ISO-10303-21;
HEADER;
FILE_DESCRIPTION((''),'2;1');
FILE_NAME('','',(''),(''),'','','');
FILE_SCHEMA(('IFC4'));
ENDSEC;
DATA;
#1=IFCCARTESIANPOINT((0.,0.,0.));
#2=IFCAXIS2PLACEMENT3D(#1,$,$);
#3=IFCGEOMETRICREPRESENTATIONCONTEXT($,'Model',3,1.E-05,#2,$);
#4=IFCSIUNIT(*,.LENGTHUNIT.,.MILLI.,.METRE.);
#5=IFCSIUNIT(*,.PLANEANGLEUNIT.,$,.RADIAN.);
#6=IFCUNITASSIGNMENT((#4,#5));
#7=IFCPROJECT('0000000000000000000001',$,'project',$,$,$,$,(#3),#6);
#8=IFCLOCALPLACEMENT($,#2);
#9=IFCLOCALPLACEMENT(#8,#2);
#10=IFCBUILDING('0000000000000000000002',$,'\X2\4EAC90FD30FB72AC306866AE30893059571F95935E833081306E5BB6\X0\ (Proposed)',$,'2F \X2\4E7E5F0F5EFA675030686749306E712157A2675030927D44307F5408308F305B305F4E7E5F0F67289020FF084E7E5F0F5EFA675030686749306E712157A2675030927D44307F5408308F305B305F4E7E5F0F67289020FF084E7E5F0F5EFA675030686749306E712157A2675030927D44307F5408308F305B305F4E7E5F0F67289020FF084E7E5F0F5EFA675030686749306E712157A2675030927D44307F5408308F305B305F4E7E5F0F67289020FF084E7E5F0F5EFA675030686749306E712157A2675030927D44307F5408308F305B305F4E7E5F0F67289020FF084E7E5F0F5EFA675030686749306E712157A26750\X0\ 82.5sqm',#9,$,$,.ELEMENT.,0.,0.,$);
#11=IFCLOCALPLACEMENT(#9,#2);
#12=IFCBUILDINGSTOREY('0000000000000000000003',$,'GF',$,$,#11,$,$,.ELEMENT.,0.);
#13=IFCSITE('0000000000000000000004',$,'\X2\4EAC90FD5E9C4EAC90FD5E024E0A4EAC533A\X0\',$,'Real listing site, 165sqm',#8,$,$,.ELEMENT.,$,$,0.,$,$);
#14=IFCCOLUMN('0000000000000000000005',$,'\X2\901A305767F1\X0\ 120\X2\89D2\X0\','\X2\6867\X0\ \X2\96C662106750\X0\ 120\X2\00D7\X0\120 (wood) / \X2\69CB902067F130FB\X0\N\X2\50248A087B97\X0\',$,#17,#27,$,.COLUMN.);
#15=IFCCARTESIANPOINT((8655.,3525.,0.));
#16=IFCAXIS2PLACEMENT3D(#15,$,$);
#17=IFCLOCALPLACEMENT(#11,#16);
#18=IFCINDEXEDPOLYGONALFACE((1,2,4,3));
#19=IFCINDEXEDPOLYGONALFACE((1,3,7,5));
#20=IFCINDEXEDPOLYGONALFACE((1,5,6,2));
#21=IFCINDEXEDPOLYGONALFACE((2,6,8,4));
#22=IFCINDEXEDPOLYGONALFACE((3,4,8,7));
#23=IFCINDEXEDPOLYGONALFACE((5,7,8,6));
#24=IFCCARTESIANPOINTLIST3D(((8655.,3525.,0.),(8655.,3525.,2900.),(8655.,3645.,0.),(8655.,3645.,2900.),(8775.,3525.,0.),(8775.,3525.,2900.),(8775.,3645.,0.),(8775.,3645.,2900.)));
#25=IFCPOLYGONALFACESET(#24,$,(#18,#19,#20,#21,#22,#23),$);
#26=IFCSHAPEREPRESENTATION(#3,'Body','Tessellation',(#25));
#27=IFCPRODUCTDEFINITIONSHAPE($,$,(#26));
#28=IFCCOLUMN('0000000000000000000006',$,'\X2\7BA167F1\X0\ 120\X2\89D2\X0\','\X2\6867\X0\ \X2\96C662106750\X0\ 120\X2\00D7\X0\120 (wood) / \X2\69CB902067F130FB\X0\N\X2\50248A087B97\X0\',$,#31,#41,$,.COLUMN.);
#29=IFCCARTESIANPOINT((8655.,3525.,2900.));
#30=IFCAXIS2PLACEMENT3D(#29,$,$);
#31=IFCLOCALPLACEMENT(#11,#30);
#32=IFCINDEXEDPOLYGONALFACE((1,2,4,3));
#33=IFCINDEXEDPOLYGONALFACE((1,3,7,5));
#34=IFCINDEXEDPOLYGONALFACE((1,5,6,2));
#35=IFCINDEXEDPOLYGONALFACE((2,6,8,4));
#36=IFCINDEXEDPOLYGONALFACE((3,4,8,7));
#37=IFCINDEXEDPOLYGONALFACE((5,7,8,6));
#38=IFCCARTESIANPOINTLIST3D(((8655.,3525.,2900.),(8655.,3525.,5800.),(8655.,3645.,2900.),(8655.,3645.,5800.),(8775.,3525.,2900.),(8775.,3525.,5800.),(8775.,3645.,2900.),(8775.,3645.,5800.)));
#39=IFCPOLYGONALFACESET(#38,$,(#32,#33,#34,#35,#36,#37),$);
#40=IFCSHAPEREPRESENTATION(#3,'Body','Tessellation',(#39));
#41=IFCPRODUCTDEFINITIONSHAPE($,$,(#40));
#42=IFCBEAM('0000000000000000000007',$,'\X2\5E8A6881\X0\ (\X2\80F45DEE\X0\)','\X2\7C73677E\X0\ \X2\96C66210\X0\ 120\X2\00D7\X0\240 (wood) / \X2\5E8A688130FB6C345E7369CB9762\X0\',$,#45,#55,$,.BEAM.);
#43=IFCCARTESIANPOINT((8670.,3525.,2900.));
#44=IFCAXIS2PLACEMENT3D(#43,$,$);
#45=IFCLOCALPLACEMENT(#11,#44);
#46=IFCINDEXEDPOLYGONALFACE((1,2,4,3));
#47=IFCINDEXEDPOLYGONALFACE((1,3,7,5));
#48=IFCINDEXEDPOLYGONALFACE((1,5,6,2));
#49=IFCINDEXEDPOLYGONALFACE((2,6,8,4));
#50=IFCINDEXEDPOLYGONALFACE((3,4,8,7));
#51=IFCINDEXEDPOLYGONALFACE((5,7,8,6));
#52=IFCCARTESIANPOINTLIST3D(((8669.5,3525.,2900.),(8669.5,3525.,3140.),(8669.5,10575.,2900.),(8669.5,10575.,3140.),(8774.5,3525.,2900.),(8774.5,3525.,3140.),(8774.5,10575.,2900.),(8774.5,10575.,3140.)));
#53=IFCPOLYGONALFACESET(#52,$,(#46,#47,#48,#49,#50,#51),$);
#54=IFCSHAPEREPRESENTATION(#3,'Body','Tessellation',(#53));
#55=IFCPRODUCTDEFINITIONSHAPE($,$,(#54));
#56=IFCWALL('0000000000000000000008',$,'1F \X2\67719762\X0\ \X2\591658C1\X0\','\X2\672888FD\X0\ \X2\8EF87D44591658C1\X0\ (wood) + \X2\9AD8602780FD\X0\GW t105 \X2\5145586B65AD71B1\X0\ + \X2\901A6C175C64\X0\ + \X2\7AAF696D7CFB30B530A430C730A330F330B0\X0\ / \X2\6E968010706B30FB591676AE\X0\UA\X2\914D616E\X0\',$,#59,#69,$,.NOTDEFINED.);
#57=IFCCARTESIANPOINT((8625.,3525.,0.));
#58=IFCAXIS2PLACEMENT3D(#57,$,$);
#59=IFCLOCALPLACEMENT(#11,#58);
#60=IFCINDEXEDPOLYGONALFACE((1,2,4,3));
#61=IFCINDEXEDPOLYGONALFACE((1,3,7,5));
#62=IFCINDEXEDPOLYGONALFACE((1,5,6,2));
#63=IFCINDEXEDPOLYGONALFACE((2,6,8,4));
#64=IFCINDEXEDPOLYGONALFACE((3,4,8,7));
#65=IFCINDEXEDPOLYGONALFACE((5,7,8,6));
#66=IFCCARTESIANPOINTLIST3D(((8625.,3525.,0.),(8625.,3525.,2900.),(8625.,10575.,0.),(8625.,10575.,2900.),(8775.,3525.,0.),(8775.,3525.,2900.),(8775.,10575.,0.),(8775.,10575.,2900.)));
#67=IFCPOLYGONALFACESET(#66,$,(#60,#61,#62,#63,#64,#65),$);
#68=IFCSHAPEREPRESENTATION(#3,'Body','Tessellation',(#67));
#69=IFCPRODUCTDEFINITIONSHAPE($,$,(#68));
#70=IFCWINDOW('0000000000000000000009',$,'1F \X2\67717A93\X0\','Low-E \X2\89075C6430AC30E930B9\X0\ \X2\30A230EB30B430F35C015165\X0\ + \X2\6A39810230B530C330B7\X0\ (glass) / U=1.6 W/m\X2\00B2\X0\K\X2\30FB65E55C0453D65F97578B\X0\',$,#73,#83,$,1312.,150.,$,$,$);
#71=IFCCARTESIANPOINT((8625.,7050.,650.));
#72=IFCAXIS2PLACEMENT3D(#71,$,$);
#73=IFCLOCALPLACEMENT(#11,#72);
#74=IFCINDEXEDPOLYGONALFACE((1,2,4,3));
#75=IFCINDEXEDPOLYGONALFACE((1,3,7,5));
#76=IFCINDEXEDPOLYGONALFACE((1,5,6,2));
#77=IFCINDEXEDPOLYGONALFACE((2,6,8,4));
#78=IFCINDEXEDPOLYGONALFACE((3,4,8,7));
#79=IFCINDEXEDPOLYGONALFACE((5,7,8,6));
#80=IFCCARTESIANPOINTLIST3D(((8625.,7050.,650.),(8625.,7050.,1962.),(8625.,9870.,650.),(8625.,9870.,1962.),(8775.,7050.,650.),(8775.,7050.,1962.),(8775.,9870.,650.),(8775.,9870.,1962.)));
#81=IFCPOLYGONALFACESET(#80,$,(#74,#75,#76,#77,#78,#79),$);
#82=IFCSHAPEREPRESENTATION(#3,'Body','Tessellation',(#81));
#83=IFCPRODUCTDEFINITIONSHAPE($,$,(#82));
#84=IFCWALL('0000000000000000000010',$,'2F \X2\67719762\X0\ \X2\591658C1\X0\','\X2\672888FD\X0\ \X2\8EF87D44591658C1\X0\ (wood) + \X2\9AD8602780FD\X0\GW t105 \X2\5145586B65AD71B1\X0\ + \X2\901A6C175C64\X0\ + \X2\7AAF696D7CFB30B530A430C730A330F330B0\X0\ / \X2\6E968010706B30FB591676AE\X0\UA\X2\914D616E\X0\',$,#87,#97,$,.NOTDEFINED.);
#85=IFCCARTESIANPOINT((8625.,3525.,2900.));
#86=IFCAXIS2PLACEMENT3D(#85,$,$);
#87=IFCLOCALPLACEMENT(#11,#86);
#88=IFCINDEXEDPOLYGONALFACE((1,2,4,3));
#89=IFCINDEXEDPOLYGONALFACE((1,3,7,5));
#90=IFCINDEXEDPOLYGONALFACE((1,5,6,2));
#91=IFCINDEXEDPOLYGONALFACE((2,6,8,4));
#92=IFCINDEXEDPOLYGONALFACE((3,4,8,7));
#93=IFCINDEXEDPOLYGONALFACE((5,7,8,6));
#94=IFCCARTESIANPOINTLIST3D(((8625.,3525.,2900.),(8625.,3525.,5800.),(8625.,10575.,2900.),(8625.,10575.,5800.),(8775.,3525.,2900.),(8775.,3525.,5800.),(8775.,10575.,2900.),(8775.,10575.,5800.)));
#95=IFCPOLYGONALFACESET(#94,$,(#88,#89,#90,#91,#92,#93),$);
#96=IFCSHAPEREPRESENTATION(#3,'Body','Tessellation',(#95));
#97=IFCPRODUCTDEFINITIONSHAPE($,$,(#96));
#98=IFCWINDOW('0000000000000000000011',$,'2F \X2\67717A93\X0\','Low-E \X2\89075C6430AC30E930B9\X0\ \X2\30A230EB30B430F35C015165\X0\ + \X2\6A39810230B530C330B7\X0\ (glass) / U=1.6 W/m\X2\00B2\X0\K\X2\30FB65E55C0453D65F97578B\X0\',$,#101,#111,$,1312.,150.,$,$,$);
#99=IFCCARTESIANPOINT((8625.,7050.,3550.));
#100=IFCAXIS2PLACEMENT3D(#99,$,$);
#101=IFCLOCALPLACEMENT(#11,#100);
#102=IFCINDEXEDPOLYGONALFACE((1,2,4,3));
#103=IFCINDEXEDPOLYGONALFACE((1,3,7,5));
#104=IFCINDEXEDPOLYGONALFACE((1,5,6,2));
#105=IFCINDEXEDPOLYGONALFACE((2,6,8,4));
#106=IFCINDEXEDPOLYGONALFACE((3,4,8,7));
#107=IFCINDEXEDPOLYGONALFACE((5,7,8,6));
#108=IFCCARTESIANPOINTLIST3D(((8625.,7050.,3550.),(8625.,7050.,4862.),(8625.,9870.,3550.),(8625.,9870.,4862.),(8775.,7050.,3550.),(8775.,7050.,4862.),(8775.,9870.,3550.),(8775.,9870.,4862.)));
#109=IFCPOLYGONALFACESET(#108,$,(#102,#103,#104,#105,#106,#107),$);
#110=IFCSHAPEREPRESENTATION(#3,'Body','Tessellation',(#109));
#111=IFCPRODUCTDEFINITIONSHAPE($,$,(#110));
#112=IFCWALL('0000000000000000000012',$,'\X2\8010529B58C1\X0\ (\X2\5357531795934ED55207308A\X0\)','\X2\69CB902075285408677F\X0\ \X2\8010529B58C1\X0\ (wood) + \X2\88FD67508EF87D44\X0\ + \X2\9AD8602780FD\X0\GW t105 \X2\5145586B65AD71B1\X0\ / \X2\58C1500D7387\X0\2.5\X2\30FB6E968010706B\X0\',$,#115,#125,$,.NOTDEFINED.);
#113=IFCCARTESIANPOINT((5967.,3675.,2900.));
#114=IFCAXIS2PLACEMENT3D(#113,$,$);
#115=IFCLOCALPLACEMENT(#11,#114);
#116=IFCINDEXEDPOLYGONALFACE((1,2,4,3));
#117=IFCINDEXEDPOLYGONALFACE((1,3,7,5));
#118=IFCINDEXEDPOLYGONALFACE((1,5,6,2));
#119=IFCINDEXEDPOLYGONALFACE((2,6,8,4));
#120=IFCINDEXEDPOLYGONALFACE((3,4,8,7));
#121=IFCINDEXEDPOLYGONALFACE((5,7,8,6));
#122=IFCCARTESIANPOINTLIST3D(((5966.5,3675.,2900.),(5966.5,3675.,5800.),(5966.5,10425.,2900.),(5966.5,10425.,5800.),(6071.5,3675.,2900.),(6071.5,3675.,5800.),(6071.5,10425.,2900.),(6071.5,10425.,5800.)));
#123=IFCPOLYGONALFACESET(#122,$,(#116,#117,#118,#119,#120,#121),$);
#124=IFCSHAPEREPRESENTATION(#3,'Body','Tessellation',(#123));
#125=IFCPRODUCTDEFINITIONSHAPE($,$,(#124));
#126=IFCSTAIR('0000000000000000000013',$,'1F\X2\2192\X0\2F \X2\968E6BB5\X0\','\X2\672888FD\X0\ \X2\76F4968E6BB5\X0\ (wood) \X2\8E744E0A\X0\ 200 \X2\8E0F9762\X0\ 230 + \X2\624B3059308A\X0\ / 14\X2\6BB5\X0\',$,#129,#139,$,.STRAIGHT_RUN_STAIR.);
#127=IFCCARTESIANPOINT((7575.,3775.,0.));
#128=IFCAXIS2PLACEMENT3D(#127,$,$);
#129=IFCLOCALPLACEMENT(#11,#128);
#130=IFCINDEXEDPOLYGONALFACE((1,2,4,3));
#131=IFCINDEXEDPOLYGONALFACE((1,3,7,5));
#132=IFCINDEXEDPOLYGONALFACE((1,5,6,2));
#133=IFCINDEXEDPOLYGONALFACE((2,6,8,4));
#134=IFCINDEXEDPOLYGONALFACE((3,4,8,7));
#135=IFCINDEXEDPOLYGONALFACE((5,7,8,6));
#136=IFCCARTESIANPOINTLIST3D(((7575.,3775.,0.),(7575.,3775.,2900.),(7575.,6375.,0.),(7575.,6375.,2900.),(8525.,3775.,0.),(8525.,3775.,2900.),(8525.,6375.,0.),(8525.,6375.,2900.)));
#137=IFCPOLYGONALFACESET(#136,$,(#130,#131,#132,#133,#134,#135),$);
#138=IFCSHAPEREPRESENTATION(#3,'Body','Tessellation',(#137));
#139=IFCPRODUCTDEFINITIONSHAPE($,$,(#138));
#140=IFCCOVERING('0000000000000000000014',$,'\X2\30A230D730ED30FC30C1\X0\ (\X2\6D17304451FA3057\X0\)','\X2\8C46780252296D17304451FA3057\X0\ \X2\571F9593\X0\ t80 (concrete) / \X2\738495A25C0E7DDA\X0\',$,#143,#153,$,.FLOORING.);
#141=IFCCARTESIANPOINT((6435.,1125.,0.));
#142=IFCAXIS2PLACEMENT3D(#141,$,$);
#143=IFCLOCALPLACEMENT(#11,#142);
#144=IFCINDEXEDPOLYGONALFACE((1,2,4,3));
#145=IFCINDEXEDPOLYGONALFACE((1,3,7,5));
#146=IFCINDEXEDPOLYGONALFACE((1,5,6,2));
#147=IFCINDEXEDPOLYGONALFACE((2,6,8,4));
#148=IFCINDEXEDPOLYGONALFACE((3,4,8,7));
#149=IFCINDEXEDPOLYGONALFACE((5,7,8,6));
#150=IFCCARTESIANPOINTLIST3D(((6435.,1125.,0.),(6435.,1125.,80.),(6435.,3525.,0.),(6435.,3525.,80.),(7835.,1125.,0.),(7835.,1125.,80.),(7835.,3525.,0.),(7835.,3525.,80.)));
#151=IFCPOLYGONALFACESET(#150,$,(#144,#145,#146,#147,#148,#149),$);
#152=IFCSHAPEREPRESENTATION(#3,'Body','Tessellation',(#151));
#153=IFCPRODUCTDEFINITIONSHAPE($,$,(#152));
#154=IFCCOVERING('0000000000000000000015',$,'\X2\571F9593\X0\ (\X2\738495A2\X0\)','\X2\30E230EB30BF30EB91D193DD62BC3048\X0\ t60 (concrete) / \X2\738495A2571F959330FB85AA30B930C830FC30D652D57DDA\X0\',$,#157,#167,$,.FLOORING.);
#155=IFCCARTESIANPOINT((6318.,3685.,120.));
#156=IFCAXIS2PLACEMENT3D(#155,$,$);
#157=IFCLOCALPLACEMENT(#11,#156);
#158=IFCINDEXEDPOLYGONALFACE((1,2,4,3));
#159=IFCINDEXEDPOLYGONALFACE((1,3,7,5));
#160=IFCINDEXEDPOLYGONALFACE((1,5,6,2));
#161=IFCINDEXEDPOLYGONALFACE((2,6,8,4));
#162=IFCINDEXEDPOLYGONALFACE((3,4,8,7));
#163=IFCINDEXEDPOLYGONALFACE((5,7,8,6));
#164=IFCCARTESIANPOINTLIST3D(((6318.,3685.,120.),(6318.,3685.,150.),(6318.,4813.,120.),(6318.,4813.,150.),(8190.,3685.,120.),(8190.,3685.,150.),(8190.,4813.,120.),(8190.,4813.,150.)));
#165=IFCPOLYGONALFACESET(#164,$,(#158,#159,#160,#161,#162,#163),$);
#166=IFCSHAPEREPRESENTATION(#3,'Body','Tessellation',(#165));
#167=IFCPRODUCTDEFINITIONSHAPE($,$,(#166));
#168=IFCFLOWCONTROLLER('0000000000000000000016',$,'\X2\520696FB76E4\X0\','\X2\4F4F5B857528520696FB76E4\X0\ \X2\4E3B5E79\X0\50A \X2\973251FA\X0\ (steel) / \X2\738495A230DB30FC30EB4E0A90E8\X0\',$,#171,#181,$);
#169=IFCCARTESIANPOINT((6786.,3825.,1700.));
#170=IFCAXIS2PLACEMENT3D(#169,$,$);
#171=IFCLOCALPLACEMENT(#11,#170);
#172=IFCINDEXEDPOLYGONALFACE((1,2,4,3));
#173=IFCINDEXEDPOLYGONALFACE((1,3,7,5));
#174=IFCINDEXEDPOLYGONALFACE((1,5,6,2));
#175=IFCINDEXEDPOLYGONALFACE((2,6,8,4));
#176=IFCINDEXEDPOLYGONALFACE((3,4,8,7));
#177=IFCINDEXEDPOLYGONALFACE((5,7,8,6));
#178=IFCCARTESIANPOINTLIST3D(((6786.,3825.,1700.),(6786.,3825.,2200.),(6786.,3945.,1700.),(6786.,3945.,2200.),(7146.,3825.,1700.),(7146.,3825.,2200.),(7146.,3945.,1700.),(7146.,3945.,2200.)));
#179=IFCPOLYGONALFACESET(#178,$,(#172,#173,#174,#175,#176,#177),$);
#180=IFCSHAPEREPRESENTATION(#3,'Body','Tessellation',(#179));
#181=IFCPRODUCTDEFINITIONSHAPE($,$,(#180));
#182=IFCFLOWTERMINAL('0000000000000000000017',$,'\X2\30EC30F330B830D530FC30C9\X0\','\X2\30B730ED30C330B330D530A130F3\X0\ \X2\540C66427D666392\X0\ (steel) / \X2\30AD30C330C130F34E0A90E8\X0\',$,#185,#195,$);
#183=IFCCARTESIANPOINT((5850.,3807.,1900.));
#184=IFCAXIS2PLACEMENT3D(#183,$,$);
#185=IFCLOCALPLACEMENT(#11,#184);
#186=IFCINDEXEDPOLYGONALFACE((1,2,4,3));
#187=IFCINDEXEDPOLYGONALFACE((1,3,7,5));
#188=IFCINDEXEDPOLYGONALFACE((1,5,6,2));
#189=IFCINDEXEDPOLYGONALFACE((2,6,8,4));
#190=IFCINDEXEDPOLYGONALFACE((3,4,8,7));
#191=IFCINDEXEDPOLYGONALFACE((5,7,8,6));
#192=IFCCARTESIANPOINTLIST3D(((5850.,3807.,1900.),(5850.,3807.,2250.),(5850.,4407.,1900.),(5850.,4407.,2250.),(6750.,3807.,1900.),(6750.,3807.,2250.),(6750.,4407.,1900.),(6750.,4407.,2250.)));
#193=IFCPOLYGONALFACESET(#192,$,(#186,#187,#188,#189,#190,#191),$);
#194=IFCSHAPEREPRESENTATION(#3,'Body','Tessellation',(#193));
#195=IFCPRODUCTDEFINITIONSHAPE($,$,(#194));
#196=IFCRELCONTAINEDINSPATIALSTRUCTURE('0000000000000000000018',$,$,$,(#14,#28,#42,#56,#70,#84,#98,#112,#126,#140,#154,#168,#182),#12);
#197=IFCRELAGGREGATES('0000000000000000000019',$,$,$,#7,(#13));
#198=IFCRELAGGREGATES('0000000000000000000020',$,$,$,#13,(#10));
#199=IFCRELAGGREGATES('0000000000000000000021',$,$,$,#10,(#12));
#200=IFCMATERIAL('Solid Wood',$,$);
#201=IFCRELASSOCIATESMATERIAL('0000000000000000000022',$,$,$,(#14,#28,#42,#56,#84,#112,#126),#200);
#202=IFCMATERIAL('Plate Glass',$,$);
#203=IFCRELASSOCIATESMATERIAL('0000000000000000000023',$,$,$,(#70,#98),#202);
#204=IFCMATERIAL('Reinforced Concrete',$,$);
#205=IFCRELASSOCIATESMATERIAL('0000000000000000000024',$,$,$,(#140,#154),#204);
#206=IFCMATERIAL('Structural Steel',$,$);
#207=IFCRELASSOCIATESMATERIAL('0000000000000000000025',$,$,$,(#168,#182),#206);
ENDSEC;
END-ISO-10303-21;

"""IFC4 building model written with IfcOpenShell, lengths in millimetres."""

from ifc_helpers import new_model, si_unit, frame, frame_2d, origin, place, context, project, spatial, rectangle, extrude, material, element, fill, save


model = new_model("IFC4")

# Units and contexts
model_context = context("Model", 3, precision=1e-05, world=origin())
ifc_project = project(units=[si_unit("LENGTHUNIT", "METRE", prefix="MILLI"), si_unit("PLANEANGLEUNIT", "RADIAN")], contexts=[model_context])

# Site, building, storey
site_placement = place(None, origin())
site = spatial("IfcSite", under=ifc_project, at=site_placement, Name="京都府京都市上京区", ObjectType="Real listing site, 165sqm", CompositionType="ELEMENT", RefElevation=0.0)
building_placement = place(site_placement, origin())
building = spatial("IfcBuilding", under=site, at=building_placement, Name="京都・犬と暮らす土間広めの家 (Proposed)", ObjectType="2F 乾式建材と杉の無垢材を組み合わせた乾式木造（乾式建材と杉の無垢材を組み合わせた乾式木造（乾式建材と杉の無垢材を組み合わせた乾式木造（乾式建材と杉の無垢材を組み合わせた乾式木造（乾式建材と杉の無垢材を組み合わせた乾式木造（乾式建材と杉の無垢材 82.5sqm", CompositionType="ELEMENT", ElevationOfRefHeight=0.0, ElevationOfTerrain=0.0)
storey_placement = place(building_placement, origin())
storey = spatial("IfcBuildingStorey", under=building, at=storey_placement, Name="GF", CompositionType="ELEMENT", Elevation=0.0)

# Columns
ifc_material_1 = material(Name="Solid Wood")
column_1_placement = place(storey_placement, frame((8655.0, 3525.0, 0.0)))
element("IfcColumn", 1, at=column_1_placement, inside=storey, material=ifc_material_1, Name="通し柱 120角", Description="桧 集成材 120×120 (wood) / 構造柱・N値計算", PredefinedType="COLUMN", context=model_context, shape_type="SweptSolid", body=[
    extrude(rectangle(XDim=120.0, YDim=120.0, at=frame_2d((60.0, 60.0))), frame((8655.0, 3525.0, 0.0)), (0.0, 0.0, 1.0), 2900.0),
])
column_2_placement = place(storey_placement, frame((8655.0, 3525.0, 2900.0)))
element("IfcColumn", 2, at=column_2_placement, inside=storey, material=ifc_material_1, Name="管柱 120角", Description="桧 集成材 120×120 (wood) / 構造柱・N値計算", PredefinedType="COLUMN", context=model_context, shape_type="SweptSolid", body=[
    extrude(rectangle(XDim=120.0, YDim=120.0, at=frame_2d((60.0, 60.0))), frame((8655.0, 3525.0, 2900.0)), (0.0, 0.0, 1.0), 2900.0),
])

# Beam
beam_1_placement = place(storey_placement, frame((8670.0, 3525.0, 2900.0)))
element("IfcBeam", 3, at=beam_1_placement, inside=storey, material=ifc_material_1, Name="床梁 (胴差)", Description="米松 集成 120×240 (wood) / 床梁・水平構面", PredefinedType="BEAM", context=model_context, shape_type="SweptSolid", body=[
    extrude(rectangle(XDim=105.0, YDim=7050.0, at=frame_2d((52.0, 3525.0))), frame((8670.0, 3525.0, 2900.0)), (0.0, 0.0, 1.0), 240.0),
])

# Wall, opening, window
wall_1_placement = place(storey_placement, frame((8625.0, 3525.0, 0.0)))
wall_1 = element("IfcWall", 4, at=wall_1_placement, inside=storey, material=ifc_material_1, Name="1F 東面 外壁", Description="木製 軸組外壁 (wood) + 高性能GW t105 充填断熱 + 通気層 + 窯業系サイディング / 準耐火・外皮UA配慮", PredefinedType="NOTDEFINED", context=model_context, shape_type="SweptSolid", body=[
    extrude(rectangle(XDim=150.0, YDim=7050.0, at=frame_2d((75.0, 3525.0))), frame((8625.0, 3525.0, 0.0)), (0.0, 0.0, 1.0), 2900.0),
])
opening_1_placement = place(storey_placement, frame((8625.0, 7050.0, 650.0)))
opening_1 = element("IfcOpeningElement", 5, at=opening_1_placement, cuts=wall_1, PredefinedType="NOTDEFINED", context=model_context, shape_type="SweptSolid", body=[
    extrude(rectangle(XDim=150.0, YDim=2820.0, at=frame_2d((75.0, 1410.0))), frame((8625.0, 7050.0, 650.0)), (0.0, 0.0, 1.0), 1312.0),
])
ifc_material_2 = material(Name="Plate Glass")
window_1_placement = place(storey_placement, frame((8625.0, 7050.0, 650.0)))
window_1 = element("IfcWindow", 6, at=window_1_placement, inside=storey, material=ifc_material_2, Name="1F 東窓", Description="Low-E 複層ガラス アルゴン封入 + 樹脂サッシ (glass) / U=1.6 W/m²K・日射取得型", OverallHeight=1312.0, OverallWidth=150.0, context=model_context, shape_type="SweptSolid", body=[
    extrude(rectangle(XDim=150.0, YDim=2820.0, at=frame_2d((75.0, 1410.0))), frame((8625.0, 7050.0, 650.0)), (0.0, 0.0, 1.0), 1312.0),
])
fill(opening_1, window_1)

# Wall, opening, window
wall_2_placement = place(storey_placement, frame((8625.0, 3525.0, 2900.0)))
wall_2 = element("IfcWall", 7, at=wall_2_placement, inside=storey, material=ifc_material_1, Name="2F 東面 外壁", Description="木製 軸組外壁 (wood) + 高性能GW t105 充填断熱 + 通気層 + 窯業系サイディング / 準耐火・外皮UA配慮", PredefinedType="NOTDEFINED", context=model_context, shape_type="SweptSolid", body=[
    extrude(rectangle(XDim=150.0, YDim=7050.0, at=frame_2d((75.0, 3525.0))), frame((8625.0, 3525.0, 2900.0)), (0.0, 0.0, 1.0), 2900.0),
])
opening_2_placement = place(storey_placement, frame((8625.0, 7050.0, 3550.0)))
opening_2 = element("IfcOpeningElement", 8, at=opening_2_placement, cuts=wall_2, PredefinedType="NOTDEFINED", context=model_context, shape_type="SweptSolid", body=[
    extrude(rectangle(XDim=150.0, YDim=2820.0, at=frame_2d((75.0, 1410.0))), frame((8625.0, 7050.0, 3550.0)), (0.0, 0.0, 1.0), 1312.0),
])
window_2_placement = place(storey_placement, frame((8625.0, 7050.0, 3550.0)))
window_2 = element("IfcWindow", 9, at=window_2_placement, inside=storey, material=ifc_material_2, Name="2F 東窓", Description="Low-E 複層ガラス アルゴン封入 + 樹脂サッシ (glass) / U=1.6 W/m²K・日射取得型", OverallHeight=1312.0, OverallWidth=150.0, context=model_context, shape_type="SweptSolid", body=[
    extrude(rectangle(XDim=150.0, YDim=2820.0, at=frame_2d((75.0, 1410.0))), frame((8625.0, 7050.0, 3550.0)), (0.0, 0.0, 1.0), 1312.0),
])
fill(opening_2, window_2)

# Wall
wall_3_placement = place(storey_placement, frame((5967.0, 3675.0, 2900.0)))
element("IfcWall", 10, at=wall_3_placement, inside=storey, material=ifc_material_1, Name="耐力壁 (南北間仕切り)", Description="構造用合板 耐力壁 (wood) + 製材軸組 + 高性能GW t105 充填断熱 / 壁倍率2.5・準耐火", PredefinedType="NOTDEFINED", context=model_context, shape_type="SweptSolid", body=[
    extrude(rectangle(XDim=105.0, YDim=6750.0, at=frame_2d((52.0, 3375.0))), frame((5967.0, 3675.0, 2900.0)), (0.0, 0.0, 1.0), 2900.0),
])

# Stair
stair_placement = place(storey_placement, frame((7575.0, 3775.0, 0.0)))
element("IfcStair", 11, at=stair_placement, inside=storey, material=ifc_material_1, Name="1F→2F 階段", Description="木製 直階段 (wood) 蹴上 200 踏面 230 + 手すり / 14段", PredefinedType="STRAIGHT_RUN_STAIR", context=model_context, shape_type="SweptSolid", body=[
    extrude(rectangle(XDim=950.0, YDim=2600.0, at=frame_2d((475.0, 1300.0))), frame((7575.0, 3775.0, 0.0)), (0.0, 0.0, 1.0), 2900.0),
])

# Coverings
ifc_material_3 = material(Name="Reinforced Concrete")
covering_1_placement = place(storey_placement, frame((6435.0, 1125.0, 0.0)))
element("IfcCovering", 12, at=covering_1_placement, inside=storey, material=ifc_material_3, Name="アプローチ (洗い出し)", Description="豆砂利洗い出し 土間 t80 (concrete) / 玄関導線", PredefinedType="FLOORING", context=model_context, shape_type="SweptSolid", body=[
    extrude(rectangle(XDim=1400.0, YDim=2400.0, at=frame_2d((700.0, 1200.0))), frame((6435.0, 1125.0, 0.0)), (0.0, 0.0, 1.0), 80.0),
])
covering_2_placement = place(storey_placement, frame((6318.0, 3685.0, 120.0)))
element("IfcCovering", 13, at=covering_2_placement, inside=storey, material=ifc_material_3, Name="土間 (玄関)", Description="モルタル金鏝押え t60 (concrete) / 玄関土間・薪ストーブ動線", PredefinedType="FLOORING", context=model_context, shape_type="SweptSolid", body=[
    extrude(rectangle(XDim=1872.0, YDim=1128.0, at=frame_2d((936.0, 564.0))), frame((6318.0, 3685.0, 120.0)), (0.0, 0.0, 1.0), 30.0),
])

# Flow controller
ifc_material_4 = material(Name="Structural Steel")
flow_controller_placement = place(storey_placement, frame((6786.0, 3825.0, 1700.0)))
element("IfcFlowController", 14, at=flow_controller_placement, inside=storey, material=ifc_material_4, Name="分電盤", Description="住宅用分電盤 主幹50A 露出 (steel) / 玄関ホール上部", context=model_context, shape_type="SweptSolid", body=[
    extrude(rectangle(XDim=360.0, YDim=120.0, at=frame_2d((180.0, 60.0))), frame((6786.0, 3825.0, 1700.0)), (0.0, 0.0, 1.0), 500.0),
])

# Flow terminal
flow_terminal_1_placement = place(storey_placement, frame((5850.0, 3807.0, 1900.0)))
element("IfcFlowTerminal", 15, at=flow_terminal_1_placement, inside=storey, material=ifc_material_4, Name="レンジフード", Description="シロッコファン 同時給排 (steel) / キッチン上部", context=model_context, shape_type="SweptSolid", body=[
    extrude(rectangle(XDim=900.0, YDim=600.0, at=frame_2d((450.0, 300.0))), frame((5850.0, 3807.0, 1900.0)), (0.0, 0.0, 1.0), 350.0),
])

save(model, "model.ifc")
